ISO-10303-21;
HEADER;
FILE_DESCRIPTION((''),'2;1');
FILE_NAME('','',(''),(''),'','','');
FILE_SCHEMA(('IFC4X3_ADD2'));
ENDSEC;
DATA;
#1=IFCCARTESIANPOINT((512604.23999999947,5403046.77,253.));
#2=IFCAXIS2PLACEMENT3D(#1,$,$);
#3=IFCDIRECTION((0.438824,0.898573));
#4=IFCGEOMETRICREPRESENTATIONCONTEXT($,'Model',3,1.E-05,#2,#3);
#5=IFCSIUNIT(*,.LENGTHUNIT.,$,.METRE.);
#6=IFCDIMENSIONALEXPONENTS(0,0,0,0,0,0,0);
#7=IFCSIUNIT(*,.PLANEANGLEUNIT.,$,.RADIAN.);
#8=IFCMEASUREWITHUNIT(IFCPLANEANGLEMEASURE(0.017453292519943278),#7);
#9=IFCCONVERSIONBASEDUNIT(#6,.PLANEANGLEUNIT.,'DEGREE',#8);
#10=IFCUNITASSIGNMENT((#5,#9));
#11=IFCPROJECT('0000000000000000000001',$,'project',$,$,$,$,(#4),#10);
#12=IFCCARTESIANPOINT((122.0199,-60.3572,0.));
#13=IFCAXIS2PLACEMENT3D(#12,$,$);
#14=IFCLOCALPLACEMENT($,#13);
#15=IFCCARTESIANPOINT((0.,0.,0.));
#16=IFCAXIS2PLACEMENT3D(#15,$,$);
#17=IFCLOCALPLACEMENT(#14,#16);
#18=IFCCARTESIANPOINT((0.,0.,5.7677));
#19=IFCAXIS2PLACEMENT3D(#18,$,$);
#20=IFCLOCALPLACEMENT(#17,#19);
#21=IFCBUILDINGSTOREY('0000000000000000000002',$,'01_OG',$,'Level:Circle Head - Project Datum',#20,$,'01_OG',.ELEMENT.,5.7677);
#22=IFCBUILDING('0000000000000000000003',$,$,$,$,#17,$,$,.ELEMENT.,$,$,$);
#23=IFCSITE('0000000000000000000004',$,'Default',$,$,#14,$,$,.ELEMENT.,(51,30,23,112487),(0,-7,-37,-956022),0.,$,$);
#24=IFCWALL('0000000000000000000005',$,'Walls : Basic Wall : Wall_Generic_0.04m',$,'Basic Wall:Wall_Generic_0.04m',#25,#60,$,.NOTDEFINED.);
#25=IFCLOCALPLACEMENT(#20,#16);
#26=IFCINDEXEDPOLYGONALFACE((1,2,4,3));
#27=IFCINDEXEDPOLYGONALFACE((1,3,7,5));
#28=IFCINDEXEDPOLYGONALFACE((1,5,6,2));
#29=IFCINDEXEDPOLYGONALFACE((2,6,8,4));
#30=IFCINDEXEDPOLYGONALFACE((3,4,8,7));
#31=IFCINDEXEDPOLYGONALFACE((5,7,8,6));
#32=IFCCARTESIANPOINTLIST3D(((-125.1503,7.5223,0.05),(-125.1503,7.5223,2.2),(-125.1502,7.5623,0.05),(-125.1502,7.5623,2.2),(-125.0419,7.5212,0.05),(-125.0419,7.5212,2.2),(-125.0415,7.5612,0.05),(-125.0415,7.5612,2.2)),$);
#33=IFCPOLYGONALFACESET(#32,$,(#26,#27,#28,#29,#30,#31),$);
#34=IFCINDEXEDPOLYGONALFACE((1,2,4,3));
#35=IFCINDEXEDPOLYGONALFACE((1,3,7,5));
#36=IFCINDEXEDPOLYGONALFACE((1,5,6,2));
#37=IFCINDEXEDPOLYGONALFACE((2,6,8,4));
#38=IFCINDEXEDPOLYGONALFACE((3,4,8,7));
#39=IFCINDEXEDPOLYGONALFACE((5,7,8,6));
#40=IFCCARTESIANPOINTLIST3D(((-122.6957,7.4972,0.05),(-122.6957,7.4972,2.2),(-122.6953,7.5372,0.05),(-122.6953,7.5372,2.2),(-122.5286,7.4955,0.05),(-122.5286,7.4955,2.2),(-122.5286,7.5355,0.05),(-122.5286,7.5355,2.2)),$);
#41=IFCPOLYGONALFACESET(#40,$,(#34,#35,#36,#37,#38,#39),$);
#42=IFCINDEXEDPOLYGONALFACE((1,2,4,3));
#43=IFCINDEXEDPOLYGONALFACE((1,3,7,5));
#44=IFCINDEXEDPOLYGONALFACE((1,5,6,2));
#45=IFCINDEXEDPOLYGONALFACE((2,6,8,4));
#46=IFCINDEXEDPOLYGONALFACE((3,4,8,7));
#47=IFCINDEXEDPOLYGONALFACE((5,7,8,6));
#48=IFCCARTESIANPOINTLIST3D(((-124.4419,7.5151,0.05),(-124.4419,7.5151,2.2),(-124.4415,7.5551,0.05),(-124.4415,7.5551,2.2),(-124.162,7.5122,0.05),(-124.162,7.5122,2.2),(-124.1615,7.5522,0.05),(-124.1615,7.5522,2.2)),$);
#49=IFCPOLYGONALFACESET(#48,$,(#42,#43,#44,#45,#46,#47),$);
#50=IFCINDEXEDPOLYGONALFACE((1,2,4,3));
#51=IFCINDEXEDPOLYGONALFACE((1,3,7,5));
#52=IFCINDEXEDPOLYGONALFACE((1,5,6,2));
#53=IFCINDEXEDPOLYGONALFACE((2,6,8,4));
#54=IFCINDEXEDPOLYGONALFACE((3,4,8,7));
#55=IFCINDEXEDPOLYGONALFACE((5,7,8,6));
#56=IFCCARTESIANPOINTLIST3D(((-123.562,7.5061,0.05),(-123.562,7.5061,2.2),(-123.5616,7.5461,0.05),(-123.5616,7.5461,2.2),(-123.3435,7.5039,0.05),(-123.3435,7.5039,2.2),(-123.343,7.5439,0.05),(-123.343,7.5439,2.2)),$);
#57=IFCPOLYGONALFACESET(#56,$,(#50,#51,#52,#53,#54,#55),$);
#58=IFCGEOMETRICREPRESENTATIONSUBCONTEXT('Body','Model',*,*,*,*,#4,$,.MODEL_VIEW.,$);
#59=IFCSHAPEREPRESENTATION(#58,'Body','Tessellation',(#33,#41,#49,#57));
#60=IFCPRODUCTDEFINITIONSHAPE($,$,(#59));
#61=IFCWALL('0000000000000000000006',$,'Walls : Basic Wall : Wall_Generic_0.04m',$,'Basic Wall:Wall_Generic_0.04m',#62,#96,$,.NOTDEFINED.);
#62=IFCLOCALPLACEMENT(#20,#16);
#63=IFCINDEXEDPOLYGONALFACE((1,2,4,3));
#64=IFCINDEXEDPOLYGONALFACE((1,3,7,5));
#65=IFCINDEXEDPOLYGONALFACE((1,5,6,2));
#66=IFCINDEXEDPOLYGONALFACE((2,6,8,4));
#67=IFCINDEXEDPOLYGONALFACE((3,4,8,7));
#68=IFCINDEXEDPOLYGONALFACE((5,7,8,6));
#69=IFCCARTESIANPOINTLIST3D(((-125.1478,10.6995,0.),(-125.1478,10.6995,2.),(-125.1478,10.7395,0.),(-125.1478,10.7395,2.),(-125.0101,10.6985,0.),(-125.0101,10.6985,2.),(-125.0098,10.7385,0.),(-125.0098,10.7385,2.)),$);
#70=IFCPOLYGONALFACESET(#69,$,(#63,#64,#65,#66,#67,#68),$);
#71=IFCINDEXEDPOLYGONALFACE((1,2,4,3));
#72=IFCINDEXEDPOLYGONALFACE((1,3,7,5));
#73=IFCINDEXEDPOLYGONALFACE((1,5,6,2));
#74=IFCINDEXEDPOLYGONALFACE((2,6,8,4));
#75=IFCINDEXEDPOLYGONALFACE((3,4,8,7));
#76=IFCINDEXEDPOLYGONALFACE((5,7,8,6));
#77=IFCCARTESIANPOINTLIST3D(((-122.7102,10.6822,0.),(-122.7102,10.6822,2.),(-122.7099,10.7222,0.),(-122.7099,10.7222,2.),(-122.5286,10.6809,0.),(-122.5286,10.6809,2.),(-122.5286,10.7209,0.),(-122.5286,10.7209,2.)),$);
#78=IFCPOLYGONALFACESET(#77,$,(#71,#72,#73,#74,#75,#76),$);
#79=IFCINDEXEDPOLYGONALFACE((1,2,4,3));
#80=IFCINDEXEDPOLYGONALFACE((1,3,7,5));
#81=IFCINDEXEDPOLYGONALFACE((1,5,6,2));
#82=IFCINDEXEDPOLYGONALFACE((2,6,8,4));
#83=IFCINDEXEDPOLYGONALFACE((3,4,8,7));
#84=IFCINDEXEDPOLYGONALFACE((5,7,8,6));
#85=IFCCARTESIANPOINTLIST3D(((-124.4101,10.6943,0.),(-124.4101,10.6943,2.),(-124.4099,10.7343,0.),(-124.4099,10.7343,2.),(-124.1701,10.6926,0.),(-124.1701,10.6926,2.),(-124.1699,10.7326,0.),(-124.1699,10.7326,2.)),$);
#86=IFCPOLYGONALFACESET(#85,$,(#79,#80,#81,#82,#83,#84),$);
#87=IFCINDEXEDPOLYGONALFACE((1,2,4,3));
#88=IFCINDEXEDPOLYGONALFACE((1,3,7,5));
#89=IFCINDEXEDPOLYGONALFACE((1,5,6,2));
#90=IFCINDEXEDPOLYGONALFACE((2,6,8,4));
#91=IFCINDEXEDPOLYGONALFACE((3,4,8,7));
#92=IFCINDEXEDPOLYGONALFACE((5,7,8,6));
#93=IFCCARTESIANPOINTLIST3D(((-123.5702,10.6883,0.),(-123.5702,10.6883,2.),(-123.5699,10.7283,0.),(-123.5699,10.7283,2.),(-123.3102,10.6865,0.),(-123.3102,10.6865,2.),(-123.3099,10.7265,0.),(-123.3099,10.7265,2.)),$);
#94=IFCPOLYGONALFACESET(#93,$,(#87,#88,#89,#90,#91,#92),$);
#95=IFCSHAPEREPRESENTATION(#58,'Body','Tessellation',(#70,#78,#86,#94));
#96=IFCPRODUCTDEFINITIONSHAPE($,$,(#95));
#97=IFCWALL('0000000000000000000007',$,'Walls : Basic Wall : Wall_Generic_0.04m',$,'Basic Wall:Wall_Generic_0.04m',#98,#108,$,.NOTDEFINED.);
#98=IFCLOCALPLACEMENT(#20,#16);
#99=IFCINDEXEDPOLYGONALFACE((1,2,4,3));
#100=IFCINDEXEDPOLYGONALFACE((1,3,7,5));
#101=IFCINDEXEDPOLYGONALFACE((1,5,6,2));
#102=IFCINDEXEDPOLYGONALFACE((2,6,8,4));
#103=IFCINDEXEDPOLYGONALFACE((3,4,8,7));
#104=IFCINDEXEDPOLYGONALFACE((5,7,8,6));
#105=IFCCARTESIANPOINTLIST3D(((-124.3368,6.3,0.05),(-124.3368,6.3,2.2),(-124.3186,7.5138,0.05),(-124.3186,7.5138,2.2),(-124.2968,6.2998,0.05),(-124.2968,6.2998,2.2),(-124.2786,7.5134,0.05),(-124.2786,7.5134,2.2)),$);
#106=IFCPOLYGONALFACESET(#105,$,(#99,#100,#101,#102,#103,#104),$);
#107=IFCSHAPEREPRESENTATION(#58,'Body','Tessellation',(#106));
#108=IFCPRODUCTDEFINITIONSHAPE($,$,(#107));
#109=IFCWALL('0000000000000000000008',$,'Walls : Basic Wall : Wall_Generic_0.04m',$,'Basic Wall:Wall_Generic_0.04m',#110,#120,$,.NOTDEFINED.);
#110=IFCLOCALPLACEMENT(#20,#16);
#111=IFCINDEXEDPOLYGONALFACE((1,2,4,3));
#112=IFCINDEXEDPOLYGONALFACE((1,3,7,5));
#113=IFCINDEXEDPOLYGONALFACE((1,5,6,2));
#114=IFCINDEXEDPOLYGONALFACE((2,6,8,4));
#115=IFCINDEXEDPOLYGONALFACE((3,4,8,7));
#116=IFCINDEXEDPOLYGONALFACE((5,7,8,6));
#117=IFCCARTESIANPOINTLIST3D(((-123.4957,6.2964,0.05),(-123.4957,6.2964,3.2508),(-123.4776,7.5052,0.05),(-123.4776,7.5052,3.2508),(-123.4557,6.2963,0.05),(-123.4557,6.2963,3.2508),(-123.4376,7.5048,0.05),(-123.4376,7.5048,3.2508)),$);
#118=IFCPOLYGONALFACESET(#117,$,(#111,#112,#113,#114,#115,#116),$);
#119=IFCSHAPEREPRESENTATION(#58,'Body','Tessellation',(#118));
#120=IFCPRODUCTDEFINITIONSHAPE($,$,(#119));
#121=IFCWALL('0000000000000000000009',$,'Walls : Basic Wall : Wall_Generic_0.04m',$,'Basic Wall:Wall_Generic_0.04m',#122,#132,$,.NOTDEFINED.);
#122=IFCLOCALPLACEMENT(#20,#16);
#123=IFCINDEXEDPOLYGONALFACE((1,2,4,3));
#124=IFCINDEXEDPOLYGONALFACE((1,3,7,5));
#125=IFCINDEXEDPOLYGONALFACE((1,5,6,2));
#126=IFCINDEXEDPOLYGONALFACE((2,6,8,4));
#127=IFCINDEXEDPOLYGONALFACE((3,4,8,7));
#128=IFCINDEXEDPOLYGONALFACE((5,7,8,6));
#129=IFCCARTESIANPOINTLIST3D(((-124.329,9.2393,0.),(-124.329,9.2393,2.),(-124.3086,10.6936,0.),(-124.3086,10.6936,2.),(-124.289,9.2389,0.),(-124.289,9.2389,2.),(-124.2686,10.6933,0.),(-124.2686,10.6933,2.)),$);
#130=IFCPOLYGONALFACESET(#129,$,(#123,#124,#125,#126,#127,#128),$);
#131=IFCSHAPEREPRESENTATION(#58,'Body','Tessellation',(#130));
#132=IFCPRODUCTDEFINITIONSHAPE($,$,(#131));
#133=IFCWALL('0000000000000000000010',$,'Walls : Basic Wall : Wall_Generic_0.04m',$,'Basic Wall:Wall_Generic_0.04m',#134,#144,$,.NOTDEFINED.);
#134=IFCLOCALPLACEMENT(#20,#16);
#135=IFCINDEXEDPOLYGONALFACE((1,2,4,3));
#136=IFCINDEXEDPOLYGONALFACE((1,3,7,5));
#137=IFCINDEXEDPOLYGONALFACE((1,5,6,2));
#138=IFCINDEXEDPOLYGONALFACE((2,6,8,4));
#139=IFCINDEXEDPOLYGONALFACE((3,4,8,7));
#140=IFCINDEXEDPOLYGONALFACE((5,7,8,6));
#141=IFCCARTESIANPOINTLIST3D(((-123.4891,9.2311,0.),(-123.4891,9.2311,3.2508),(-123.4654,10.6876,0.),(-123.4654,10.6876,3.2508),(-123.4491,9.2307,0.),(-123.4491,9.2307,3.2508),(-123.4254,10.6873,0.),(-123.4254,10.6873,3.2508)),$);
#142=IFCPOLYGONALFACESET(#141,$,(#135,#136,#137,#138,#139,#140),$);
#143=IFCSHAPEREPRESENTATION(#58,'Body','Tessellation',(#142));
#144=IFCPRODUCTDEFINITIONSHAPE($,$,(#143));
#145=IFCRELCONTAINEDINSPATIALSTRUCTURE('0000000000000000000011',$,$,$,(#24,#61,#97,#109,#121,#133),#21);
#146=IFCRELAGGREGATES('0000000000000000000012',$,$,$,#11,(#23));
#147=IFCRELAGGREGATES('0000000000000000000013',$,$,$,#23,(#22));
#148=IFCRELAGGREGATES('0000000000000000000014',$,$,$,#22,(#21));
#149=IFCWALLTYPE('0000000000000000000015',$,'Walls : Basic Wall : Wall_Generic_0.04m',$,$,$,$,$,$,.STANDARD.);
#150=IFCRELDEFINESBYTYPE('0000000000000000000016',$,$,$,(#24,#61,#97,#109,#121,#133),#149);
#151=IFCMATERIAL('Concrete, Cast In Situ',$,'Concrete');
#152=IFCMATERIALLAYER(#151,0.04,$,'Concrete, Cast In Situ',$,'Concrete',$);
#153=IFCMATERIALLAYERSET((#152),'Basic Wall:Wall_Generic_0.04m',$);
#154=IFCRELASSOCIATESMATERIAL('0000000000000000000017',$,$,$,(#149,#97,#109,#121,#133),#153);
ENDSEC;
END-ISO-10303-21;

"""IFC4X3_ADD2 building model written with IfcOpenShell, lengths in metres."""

from ifc_helpers import new_model, entity, si_unit, converted_unit, direction, frame, frame_2d, origin, place, context, subcontext, project, spatial, polyline, rectangle, outline, extrude, material, layer, layer_set, type_object, element, save


model = new_model("IFC4X3_ADD2")

# Units and contexts
model_context = context("Model", 3, precision=1e-05, world=frame((512604.23999999947, 5403046.77, 253.0)), true_north=direction((0.438824, 0.898573)))
body_context = subcontext(model_context, "Body", "Model", "MODEL_VIEW")
ifc_project = project(units=[si_unit("LENGTHUNIT", "METRE"), converted_unit("PLANEANGLEUNIT", "DEGREE", entity("IfcPlaneAngleMeasure", 0.017453292519943278), si_unit("PLANEANGLEUNIT", "RADIAN"), dimensions=[0, 0, 0, 0, 0, 0, 0])], contexts=[model_context])

# Site, building, storey
site_placement = place(None, frame((122.0199, -60.3572, 0.0)))
site = spatial("IfcSite", under=ifc_project, at=site_placement, Name="Default", CompositionType="ELEMENT", RefLatitude=(51, 30, 23, 112487), RefLongitude=(0, -7, -37, -956022), RefElevation=0.0)
building_placement = place(site_placement, origin())
building = spatial("IfcBuilding", under=site, at=building_placement, CompositionType="ELEMENT")
storey_placement = place(building_placement, frame((0.0, 0.0, 5.7677)))
storey = spatial("IfcBuildingStorey", under=building, at=storey_placement, Name="01_OG", ObjectType="Level:Circle Head - Project Datum", LongName="01_OG", CompositionType="ELEMENT", Elevation=5.7677)

# Shared definitions
ifc_material_1 = material(Name="Concrete, Cast In Situ", Category="Concrete")

# Walls
ifc_layer_1 = layer(ifc_material_1, 0.04, Name="Concrete, Cast In Situ", Category="Concrete")
ifc_layer_set_1 = layer_set([ifc_layer_1], Name="Basic Wall:Wall_Generic_0.04m")
wall_type_1 = type_object("IfcWallType", Name="Walls : Basic Wall : Wall_Generic_0.04m", PredefinedType="STANDARD", material=ifc_layer_set_1)
wall_1_placement = place(storey_placement, frame((-125.1504, 7.5423, 0.05), z_axis=(0.0, 0.0, 1.0), x_axis=(0.999948, -0.010227, 0.0)))
element("IfcWall", 1, at=wall_1_placement, inside=storey, type_object=wall_type_1, Name="Walls : Basic Wall : Wall_Generic_0.04m", ObjectType="Basic Wall:Wall_Generic_0.04m", PredefinedType="NOTDEFINED", context=body_context, shape_type="SweptSolid", body=[
    extrude(outline(polyline([(-0.0541, -0.02), (0.0543, -0.02), (0.0543, 0.02), (-0.0545, 0.02), (-0.0541, -0.02)])), frame((0.0545, 0.0, 0.0)), (0.0, 0.0, 1.0), 2.15),
    extrude(outline(polyline([(-0.0832, -0.02), (0.0835, -0.02), (0.0835, 0.02), (-0.0837, 0.02), (-0.0832, -0.02)])), frame((2.5385, 0.0, 0.0), z_axis=(0.0, 0.0, 1.0), x_axis=(-1.0, 0.0, 0.0)), (0.0, 0.0, 1.0), 2.15),
    extrude(rectangle(XDim=0.28, YDim=0.04, at=frame_2d((-0.0145, 0.0086), x_axis=(1.0, 0.0))), frame((0.8633, -0.0086, 0.0)), (0.0, 0.0, 1.0), 2.15),
    extrude(rectangle(XDim=0.2185, YDim=0.04, at=frame_2d((-0.0136, 0.0086), x_axis=(1.0, 0.0))), frame((1.7117, -0.0086, 0.0)), (0.0, 0.0, 1.0), 2.15),
])
wall_2_placement = place(storey_placement, frame((-125.1479, 10.7195, 0.0), z_axis=(0.0, 0.0, 1.0), x_axis=(0.999975, -0.007095, 0.0)))
element("IfcWall", 2, at=wall_2_placement, inside=storey, type_object=wall_type_1, Name="Walls : Basic Wall : Wall_Generic_0.04m", ObjectType="Basic Wall:Wall_Generic_0.04m", PredefinedType="NOTDEFINED", context=body_context, shape_type="SweptSolid", body=[
    extrude(outline(polyline([(-0.0688, -0.02), (0.0689, -0.02), (0.0689, 0.02), (-0.069, 0.02), (-0.0688, -0.02)])), frame((0.069, 0.0, 0.0)), (0.0, 0.0, 1.0), 2.0),
    extrude(outline(polyline([(-0.0906, -0.02), (0.0907, -0.02), (0.0907, 0.02), (-0.0908, 0.02), (-0.0906, -0.02)])), frame((2.5286, 0.0, 0.0), z_axis=(0.0, 0.0, 1.0), x_axis=(-1.0, 0.0, 0.0)), (0.0, 0.0, 1.0), 2.0),
    extrude(rectangle(XDim=0.24, YDim=0.04, at=frame_2d((-0.0169, 0.0086), x_axis=(1.0, 0.0))), frame((0.8748, -0.0086, 0.0)), (0.0, 0.0, 1.0), 2.0),
    extrude(rectangle(XDim=0.26, YDim=0.04, at=frame_2d((-0.0135, 0.0086), x_axis=(1.0, 0.0))), frame((1.7215, -0.0086, 0.0)), (0.0, 0.0, 1.0), 2.0),
])
wall_3_placement = place(storey_placement, frame((-124.3168, 6.2997, 0.05), z_axis=(0.0, 0.0, 1.0), x_axis=(0.014987, 0.999888, 0.0)))
element("IfcWall", 3, at=wall_3_placement, inside=storey, type_object=wall_type_1, material=ifc_layer_set_1, Name="Walls : Basic Wall : Wall_Generic_0.04m", ObjectType="Basic Wall:Wall_Generic_0.04m", PredefinedType="NOTDEFINED", context=body_context, shape_type="SweptSolid", body=[
    extrude(outline(polyline([(1.2142, -0.02), (1.214, 0.02), (0.0, 0.02), (0.0004, -0.02), (1.2142, -0.02)])), origin(), (0.0, 0.0, 1.0), 2.15),
])
wall_4_placement = place(storey_placement, frame((-123.4757, 6.2961, 0.05), z_axis=(0.0, 0.0, 1.0), x_axis=(0.014987, 0.999888, 0.0)))
element("IfcWall", 4, at=wall_4_placement, inside=storey, type_object=wall_type_1, material=ifc_layer_set_1, Name="Walls : Basic Wall : Wall_Generic_0.04m", ObjectType="Basic Wall:Wall_Generic_0.04m", PredefinedType="NOTDEFINED", context=body_context, shape_type="SweptSolid", body=[
    extrude(outline(polyline([(1.2091, -0.02), (1.2089, 0.02), (0.0, 0.02), (0.0004, -0.02), (1.2091, -0.02)])), origin(), (0.0, 0.0, 1.0), 3.2008),
])
wall_5_placement = place(storey_placement, frame((-124.309, 9.239, 0.0), z_axis=(0.0, 0.0, 1.0), x_axis=(0.014051, 0.999901, 0.0)))
element("IfcWall", 5, at=wall_5_placement, inside=storey, type_object=wall_type_1, material=ifc_layer_set_1, Name="Walls : Basic Wall : Wall_Generic_0.04m", ObjectType="Basic Wall:Wall_Generic_0.04m", PredefinedType="NOTDEFINED", context=body_context, shape_type="SweptSolid", body=[
    extrude(outline(polyline([(1.4547, -0.02), (1.4545, 0.02), (0.0, 0.02), (0.0002, -0.02), (1.4547, -0.02)])), origin(), (0.0, 0.0, 1.0), 2.0),
])
wall_6_placement = place(storey_placement, frame((-123.4691, 9.2308, 0.0), z_axis=(0.0, 0.0, 1.0), x_axis=(0.016281, 0.999867, 0.0)))
element("IfcWall", 6, at=wall_6_placement, inside=storey, type_object=wall_type_1, material=ifc_layer_set_1, Name="Walls : Basic Wall : Wall_Generic_0.04m", ObjectType="Basic Wall:Wall_Generic_0.04m", PredefinedType="NOTDEFINED", context=body_context, shape_type="SweptSolid", body=[
    extrude(outline(polyline([(1.457, -0.02), (1.4567, 0.02), (0.0, 0.02), (0.0003, -0.02), (1.457, -0.02)])), origin(), (0.0, 0.0, 1.0), 3.2508),
])

save(model, "model.ifc")
